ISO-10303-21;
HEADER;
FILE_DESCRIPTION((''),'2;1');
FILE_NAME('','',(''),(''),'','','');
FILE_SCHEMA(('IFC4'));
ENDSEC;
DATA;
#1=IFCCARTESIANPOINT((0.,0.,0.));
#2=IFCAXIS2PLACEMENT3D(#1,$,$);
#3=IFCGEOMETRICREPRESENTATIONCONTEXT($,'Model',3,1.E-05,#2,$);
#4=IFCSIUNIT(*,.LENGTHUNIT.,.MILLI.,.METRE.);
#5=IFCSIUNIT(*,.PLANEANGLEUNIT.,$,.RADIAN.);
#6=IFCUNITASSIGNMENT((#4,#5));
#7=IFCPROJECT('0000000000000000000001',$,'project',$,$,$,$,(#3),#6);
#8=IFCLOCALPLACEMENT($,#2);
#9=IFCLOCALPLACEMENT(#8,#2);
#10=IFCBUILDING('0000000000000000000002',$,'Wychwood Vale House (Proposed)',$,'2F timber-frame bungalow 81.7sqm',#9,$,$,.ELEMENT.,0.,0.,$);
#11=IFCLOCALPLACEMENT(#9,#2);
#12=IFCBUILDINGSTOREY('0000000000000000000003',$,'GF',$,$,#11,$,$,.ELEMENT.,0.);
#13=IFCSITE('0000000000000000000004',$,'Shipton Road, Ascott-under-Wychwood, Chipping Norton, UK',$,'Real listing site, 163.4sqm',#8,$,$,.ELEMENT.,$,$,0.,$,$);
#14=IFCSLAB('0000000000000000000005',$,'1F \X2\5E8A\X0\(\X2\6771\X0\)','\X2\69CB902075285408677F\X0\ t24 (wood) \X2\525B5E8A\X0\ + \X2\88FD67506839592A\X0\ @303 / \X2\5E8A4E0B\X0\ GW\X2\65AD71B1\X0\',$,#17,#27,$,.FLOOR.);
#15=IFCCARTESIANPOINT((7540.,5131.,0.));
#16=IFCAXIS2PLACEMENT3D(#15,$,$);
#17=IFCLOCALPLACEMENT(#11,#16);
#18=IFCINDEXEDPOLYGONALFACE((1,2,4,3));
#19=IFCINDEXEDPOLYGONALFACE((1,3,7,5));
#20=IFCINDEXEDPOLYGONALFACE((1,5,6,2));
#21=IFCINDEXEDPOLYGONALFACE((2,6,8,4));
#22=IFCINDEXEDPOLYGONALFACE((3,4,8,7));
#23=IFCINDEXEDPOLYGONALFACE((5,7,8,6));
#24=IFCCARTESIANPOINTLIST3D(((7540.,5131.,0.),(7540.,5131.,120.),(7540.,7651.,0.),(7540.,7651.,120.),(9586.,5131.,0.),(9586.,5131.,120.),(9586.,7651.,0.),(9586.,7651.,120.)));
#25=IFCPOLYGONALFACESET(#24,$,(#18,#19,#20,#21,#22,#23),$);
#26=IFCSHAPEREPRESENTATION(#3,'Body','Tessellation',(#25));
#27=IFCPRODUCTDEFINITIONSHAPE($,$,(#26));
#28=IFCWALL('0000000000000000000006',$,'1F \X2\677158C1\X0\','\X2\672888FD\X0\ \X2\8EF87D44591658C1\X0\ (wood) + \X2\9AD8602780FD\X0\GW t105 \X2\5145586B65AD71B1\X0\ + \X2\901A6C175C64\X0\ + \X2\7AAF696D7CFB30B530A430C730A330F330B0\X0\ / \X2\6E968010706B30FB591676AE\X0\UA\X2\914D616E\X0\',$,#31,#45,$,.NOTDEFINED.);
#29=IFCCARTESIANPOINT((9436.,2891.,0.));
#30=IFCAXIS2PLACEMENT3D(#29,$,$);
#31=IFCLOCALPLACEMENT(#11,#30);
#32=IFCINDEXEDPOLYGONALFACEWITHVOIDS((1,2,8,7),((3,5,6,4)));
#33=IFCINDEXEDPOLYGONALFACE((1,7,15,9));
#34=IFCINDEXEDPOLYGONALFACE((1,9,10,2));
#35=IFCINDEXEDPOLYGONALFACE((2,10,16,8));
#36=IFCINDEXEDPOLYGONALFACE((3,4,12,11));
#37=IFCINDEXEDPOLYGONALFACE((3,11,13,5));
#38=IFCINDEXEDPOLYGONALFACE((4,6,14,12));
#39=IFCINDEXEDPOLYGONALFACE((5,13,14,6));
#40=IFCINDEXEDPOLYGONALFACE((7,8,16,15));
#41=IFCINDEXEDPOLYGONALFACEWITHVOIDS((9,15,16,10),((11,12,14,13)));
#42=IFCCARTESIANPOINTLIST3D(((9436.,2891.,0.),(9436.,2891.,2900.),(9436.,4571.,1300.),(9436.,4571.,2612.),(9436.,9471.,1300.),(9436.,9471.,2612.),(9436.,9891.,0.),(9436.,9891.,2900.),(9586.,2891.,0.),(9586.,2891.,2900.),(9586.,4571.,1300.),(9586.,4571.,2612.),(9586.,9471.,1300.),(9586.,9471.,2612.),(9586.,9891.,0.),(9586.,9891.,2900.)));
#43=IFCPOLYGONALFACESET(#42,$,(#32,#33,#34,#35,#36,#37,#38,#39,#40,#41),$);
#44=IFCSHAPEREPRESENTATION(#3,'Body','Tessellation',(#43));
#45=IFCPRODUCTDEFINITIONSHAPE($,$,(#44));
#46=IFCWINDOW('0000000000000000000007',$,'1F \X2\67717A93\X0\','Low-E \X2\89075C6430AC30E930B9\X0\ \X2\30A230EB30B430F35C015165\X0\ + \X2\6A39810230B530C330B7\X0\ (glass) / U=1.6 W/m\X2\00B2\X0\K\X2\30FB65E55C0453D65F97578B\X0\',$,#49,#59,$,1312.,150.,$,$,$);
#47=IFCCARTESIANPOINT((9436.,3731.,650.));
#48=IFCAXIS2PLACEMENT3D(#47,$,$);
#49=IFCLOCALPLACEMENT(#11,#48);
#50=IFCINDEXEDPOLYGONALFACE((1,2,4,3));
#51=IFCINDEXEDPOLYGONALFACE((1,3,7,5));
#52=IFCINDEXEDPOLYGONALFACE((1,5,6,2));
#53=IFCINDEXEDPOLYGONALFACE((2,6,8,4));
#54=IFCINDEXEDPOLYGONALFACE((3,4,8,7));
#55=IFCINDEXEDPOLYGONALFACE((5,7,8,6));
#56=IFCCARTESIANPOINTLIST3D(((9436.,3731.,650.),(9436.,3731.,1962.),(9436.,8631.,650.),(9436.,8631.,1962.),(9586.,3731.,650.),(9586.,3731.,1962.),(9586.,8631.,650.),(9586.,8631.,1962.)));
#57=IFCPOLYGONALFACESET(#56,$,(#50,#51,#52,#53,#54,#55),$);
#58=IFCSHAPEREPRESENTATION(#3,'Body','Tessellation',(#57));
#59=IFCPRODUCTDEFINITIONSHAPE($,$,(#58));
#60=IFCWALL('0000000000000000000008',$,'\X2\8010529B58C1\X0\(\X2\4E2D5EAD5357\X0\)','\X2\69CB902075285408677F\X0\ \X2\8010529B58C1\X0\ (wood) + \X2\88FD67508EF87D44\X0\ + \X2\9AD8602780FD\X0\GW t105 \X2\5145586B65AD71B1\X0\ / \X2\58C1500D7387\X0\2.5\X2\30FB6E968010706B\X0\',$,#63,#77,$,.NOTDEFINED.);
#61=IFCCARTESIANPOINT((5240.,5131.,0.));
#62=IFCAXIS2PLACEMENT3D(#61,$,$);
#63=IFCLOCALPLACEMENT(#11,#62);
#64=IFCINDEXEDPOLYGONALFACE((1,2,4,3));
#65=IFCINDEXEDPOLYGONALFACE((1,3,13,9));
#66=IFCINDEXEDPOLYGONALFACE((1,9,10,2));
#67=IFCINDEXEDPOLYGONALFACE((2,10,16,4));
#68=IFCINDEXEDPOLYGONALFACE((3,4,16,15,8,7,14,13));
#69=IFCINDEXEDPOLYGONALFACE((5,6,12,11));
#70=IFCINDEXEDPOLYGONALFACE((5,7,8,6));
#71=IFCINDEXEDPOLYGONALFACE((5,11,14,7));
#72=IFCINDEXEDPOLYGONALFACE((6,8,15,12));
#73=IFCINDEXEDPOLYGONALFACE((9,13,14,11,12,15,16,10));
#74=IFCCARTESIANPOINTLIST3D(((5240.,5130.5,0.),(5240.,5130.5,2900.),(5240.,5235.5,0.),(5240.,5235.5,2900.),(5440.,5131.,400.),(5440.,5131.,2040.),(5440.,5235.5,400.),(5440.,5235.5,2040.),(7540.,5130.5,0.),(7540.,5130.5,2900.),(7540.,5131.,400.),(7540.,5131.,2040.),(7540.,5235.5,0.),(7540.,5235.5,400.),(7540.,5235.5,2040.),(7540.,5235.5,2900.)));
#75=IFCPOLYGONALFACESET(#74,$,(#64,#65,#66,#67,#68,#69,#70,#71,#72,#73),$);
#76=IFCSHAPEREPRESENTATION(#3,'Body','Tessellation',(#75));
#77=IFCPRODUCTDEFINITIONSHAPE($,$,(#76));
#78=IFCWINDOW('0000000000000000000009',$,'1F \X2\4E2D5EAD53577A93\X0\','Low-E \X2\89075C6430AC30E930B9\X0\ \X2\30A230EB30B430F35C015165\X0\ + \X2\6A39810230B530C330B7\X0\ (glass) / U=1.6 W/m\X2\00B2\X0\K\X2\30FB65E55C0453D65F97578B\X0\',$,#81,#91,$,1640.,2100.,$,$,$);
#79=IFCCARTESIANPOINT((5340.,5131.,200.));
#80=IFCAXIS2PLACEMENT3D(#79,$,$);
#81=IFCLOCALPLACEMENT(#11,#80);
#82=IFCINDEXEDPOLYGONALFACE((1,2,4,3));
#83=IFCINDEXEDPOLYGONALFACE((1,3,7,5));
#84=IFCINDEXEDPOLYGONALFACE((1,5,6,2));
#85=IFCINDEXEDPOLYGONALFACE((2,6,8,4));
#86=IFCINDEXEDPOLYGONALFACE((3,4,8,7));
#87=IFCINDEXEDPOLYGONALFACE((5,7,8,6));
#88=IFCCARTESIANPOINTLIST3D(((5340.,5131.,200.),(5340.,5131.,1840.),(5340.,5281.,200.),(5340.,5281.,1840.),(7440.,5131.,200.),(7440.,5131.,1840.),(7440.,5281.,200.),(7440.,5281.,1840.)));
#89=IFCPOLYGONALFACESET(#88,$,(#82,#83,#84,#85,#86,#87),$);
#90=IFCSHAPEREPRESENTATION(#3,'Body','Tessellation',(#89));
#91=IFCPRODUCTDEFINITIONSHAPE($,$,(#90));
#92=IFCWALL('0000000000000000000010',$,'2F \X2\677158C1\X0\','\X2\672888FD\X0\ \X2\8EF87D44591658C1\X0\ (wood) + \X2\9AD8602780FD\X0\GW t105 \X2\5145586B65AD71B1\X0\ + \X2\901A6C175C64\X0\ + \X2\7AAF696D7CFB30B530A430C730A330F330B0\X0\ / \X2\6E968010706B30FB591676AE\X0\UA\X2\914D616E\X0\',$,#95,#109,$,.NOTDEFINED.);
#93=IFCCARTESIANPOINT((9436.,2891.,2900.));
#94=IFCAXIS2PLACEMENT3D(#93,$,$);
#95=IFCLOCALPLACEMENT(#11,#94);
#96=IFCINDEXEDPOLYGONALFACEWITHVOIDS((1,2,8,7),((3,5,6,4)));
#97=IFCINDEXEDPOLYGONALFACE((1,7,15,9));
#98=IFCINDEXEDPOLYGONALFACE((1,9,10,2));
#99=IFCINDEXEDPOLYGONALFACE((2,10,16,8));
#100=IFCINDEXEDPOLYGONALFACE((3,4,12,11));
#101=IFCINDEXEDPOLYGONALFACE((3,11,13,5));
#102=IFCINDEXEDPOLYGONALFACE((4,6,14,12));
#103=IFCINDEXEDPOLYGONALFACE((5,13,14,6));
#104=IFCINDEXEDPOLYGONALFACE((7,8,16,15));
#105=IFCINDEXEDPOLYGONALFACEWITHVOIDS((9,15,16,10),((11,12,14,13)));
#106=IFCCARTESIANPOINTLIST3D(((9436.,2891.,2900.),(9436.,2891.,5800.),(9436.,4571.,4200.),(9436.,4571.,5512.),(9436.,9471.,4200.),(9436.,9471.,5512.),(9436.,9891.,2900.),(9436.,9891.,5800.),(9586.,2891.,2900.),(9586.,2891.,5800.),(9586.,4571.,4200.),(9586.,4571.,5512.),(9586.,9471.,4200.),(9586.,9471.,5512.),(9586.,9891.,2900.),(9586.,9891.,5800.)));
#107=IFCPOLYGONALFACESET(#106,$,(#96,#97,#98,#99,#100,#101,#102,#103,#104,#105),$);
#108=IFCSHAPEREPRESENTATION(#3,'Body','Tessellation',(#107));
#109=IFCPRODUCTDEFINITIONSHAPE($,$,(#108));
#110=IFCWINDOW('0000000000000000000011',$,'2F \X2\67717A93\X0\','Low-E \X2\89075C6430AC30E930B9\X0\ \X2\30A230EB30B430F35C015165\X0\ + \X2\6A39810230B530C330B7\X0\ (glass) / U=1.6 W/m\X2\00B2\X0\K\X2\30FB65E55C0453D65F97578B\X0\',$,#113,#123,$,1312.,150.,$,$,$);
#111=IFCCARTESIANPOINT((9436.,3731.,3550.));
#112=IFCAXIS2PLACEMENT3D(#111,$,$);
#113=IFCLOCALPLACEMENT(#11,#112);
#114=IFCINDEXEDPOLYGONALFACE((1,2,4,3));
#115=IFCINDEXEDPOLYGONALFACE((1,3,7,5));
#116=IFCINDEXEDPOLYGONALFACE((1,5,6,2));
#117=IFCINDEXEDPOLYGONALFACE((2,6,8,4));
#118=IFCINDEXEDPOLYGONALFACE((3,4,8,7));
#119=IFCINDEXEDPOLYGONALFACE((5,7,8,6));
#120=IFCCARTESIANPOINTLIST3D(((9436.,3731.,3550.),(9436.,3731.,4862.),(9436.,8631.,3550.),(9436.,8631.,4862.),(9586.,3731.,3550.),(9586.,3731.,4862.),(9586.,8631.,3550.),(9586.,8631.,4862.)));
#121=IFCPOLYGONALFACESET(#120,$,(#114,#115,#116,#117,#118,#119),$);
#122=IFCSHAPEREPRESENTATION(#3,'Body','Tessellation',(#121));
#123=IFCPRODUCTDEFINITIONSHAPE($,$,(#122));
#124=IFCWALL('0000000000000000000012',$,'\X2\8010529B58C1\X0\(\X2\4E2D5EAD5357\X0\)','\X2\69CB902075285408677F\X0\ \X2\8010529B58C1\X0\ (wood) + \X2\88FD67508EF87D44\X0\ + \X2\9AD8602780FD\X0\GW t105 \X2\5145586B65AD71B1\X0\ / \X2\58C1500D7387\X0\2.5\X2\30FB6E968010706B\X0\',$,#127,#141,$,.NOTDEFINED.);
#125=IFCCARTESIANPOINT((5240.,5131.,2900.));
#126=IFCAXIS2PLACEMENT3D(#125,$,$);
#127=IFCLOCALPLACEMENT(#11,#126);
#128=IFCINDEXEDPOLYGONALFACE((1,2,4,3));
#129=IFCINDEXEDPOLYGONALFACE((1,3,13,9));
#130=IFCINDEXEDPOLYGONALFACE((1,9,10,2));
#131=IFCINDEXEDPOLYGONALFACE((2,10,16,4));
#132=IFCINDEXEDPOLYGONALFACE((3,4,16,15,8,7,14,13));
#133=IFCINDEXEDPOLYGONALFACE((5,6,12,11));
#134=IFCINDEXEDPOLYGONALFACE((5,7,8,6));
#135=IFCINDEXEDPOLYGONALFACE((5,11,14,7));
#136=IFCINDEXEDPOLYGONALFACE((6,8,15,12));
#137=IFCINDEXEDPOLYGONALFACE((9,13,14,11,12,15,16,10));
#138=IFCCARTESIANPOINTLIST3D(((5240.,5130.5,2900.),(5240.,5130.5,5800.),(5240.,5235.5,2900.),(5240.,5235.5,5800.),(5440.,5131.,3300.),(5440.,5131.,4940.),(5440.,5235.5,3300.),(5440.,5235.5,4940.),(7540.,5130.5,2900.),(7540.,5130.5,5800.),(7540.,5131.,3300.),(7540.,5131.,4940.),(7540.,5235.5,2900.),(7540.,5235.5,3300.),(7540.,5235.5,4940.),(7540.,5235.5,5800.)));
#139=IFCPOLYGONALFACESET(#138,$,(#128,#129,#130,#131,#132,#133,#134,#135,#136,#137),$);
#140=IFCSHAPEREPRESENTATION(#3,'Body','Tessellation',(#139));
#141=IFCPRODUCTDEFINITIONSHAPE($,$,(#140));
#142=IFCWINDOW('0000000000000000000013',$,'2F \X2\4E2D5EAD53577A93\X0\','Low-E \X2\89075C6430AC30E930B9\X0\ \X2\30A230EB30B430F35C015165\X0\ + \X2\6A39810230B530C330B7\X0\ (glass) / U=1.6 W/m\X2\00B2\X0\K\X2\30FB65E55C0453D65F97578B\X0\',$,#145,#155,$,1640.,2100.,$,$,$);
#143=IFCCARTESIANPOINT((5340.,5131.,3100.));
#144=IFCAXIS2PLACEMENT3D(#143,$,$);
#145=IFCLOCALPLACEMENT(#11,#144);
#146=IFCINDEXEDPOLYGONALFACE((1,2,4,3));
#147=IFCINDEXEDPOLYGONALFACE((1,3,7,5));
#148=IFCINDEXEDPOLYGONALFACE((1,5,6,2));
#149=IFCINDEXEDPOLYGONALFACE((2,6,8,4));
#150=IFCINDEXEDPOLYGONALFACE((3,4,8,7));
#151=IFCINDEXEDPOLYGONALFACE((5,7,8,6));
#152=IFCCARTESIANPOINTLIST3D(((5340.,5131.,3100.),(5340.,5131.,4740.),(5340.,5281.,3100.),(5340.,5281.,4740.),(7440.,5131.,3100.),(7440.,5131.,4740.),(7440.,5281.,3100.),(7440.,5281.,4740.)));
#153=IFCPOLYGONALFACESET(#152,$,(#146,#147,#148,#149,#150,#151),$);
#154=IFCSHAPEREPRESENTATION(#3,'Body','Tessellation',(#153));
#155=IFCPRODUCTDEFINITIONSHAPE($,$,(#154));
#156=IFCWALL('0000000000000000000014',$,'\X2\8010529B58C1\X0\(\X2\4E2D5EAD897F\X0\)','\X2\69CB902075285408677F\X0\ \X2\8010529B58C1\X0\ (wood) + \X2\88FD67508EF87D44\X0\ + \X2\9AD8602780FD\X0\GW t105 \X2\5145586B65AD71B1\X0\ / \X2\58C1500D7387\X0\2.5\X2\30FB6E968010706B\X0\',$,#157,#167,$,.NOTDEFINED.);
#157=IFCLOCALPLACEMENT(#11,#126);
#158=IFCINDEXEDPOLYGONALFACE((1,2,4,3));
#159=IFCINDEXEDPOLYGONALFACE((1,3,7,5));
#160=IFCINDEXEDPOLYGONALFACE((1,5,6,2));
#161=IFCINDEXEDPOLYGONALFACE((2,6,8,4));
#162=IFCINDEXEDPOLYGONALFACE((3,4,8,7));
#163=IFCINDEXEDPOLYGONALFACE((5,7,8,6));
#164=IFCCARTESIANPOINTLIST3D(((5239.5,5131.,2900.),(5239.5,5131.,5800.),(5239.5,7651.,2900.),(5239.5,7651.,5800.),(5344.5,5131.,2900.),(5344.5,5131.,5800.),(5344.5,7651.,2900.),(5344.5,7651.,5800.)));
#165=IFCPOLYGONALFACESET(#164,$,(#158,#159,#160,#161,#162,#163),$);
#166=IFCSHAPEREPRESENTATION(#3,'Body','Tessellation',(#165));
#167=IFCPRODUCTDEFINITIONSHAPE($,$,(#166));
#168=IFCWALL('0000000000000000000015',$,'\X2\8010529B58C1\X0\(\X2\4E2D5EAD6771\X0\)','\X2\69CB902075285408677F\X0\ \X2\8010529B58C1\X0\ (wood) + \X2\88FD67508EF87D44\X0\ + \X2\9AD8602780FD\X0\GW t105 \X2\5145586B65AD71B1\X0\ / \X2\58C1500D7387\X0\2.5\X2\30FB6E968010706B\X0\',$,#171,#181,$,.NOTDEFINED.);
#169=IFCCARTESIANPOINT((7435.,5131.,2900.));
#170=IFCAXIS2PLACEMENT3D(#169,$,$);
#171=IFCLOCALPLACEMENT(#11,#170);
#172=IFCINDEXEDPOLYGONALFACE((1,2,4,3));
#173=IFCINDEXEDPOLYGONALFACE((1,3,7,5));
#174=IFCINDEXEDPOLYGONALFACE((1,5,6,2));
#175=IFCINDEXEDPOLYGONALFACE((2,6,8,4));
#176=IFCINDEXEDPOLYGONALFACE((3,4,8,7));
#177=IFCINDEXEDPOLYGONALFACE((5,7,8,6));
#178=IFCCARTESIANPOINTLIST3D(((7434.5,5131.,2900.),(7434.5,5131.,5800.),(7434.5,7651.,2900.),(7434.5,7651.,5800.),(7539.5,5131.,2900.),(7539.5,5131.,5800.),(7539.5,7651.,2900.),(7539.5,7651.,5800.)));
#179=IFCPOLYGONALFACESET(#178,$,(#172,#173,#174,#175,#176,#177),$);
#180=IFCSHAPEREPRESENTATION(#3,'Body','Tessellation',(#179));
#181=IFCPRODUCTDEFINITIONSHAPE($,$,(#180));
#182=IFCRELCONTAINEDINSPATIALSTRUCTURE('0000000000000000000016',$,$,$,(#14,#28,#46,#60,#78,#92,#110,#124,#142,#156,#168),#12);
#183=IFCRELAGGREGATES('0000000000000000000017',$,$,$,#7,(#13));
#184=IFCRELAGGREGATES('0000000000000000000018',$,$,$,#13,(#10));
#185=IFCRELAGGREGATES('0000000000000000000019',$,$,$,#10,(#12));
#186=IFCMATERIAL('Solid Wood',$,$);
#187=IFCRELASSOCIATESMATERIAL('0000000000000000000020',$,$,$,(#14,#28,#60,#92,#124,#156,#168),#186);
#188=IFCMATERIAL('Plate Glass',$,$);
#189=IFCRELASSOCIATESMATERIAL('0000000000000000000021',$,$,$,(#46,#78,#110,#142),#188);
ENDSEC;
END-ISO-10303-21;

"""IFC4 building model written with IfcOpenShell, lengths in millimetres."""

from ifc_helpers import new_model, si_unit, frame, frame_2d, origin, place, context, project, spatial, rectangle, extrude, material, element, fill, save


model = new_model("IFC4")

# Units and contexts
model_context = context("Model", 3, precision=1e-05, world=origin())
ifc_project = project(units=[si_unit("LENGTHUNIT", "METRE", prefix="MILLI"), si_unit("PLANEANGLEUNIT", "RADIAN")], contexts=[model_context])

# Site, building, storey
site_placement = place(None, origin())
site = spatial("IfcSite", under=ifc_project, at=site_placement, Name="Shipton Road, Ascott-under-Wychwood, Chipping Norton, UK", ObjectType="Real listing site, 163.4sqm", CompositionType="ELEMENT", RefElevation=0.0)
building_placement = place(site_placement, origin())
building = spatial("IfcBuilding", under=site, at=building_placement, Name="Wychwood Vale House (Proposed)", ObjectType="2F timber-frame bungalow 81.7sqm", CompositionType="ELEMENT", ElevationOfRefHeight=0.0, ElevationOfTerrain=0.0)
storey_placement = place(building_placement, origin())
storey = spatial("IfcBuildingStorey", under=building, at=storey_placement, Name="GF", CompositionType="ELEMENT", Elevation=0.0)

# Slab
ifc_material_1 = material(Name="Solid Wood")
slab_placement = place(storey_placement, frame((7540.0, 5131.0, 0.0)))
element("IfcSlab", 1, at=slab_placement, inside=storey, material=ifc_material_1, Name="1F 床(東)", Description="構造用合板 t24 (wood) 剛床 + 製材根太 @303 / 床下 GW断熱", PredefinedType="FLOOR", context=model_context, shape_type="SweptSolid", body=[
    extrude(rectangle(XDim=2046.0, YDim=2520.0, at=frame_2d((1023.0, 1260.0))), frame((7540.0, 5131.0, 0.0)), (0.0, 0.0, 1.0), 120.0),
])

# Walls, openings, windows
wall_1_placement = place(storey_placement, frame((9436.0, 2891.0, 0.0)))
wall_1 = element("IfcWall", 2, at=wall_1_placement, inside=storey, material=ifc_material_1, Name="1F 東壁", Description="木製 軸組外壁 (wood) + 高性能GW t105 充填断熱 + 通気層 + 窯業系サイディング / 準耐火・外皮UA配慮", PredefinedType="NOTDEFINED", context=model_context, shape_type="SweptSolid", body=[
    extrude(rectangle(XDim=150.0, YDim=7000.0, at=frame_2d((75.0, 3500.0))), frame((9436.0, 2891.0, 0.0)), (0.0, 0.0, 1.0), 2900.0),
])
opening_1_placement = place(storey_placement, frame((9436.0, 3731.0, 650.0)))
opening_1 = element("IfcOpeningElement", 3, at=opening_1_placement, cuts=wall_1, PredefinedType="NOTDEFINED", context=model_context, shape_type="SweptSolid", body=[
    extrude(rectangle(XDim=150.0, YDim=4900.0, at=frame_2d((75.0, 2450.0))), frame((9436.0, 3731.0, 650.0)), (0.0, 0.0, 1.0), 1312.0),
])
ifc_material_2 = material(Name="Plate Glass")
window_1_placement = place(storey_placement, frame((9436.0, 3731.0, 650.0)))
window_1 = element("IfcWindow", 4, at=window_1_placement, inside=storey, material=ifc_material_2, Name="1F 東窓", Description="Low-E 複層ガラス アルゴン封入 + 樹脂サッシ (glass) / U=1.6 W/m²K・日射取得型", OverallHeight=1312.0, OverallWidth=150.0, context=model_context, shape_type="SweptSolid", body=[
    extrude(rectangle(XDim=150.0, YDim=4900.0, at=frame_2d((75.0, 2450.0))), frame((9436.0, 3731.0, 650.0)), (0.0, 0.0, 1.0), 1312.0),
])
fill(opening_1, window_1)
wall_2_placement = place(storey_placement, frame((5240.0, 5131.0, 0.0)))
wall_2 = element("IfcWall", 5, at=wall_2_placement, inside=storey, material=ifc_material_1, Name="耐力壁(中庭南)", Description="構造用合板 耐力壁 (wood) + 製材軸組 + 高性能GW t105 充填断熱 / 壁倍率2.5・準耐火", PredefinedType="NOTDEFINED", context=model_context, shape_type="SweptSolid", body=[
    extrude(rectangle(XDim=2300.0, YDim=105.0, at=frame_2d((1150.0, 52.0))), frame((5240.0, 5131.0, 0.0)), (0.0, 0.0, 1.0), 2900.0),
])
opening_2_placement = place(storey_placement, frame((5340.0, 5131.0, 200.0)))
opening_2 = element("IfcOpeningElement", 6, at=opening_2_placement, cuts=wall_2, PredefinedType="NOTDEFINED", context=model_context, shape_type="SweptSolid", body=[
    extrude(rectangle(XDim=2100.0, YDim=150.0, at=frame_2d((1050.0, 75.0))), frame((5340.0, 5131.0, 200.0)), (0.0, 0.0, 1.0), 1640.0),
])
window_2_placement = place(storey_placement, frame((5340.0, 5131.0, 200.0)))
window_2 = element("IfcWindow", 7, at=window_2_placement, inside=storey, material=ifc_material_2, Name="1F 中庭南窓", Description="Low-E 複層ガラス アルゴン封入 + 樹脂サッシ (glass) / U=1.6 W/m²K・日射取得型", OverallHeight=1640.0, OverallWidth=2100.0, context=model_context, shape_type="SweptSolid", body=[
    extrude(rectangle(XDim=2100.0, YDim=150.0, at=frame_2d((1050.0, 75.0))), frame((5340.0, 5131.0, 200.0)), (0.0, 0.0, 1.0), 1640.0),
])
fill(opening_2, window_2)

# Walls, openings, windows
wall_3_placement = place(storey_placement, frame((9436.0, 2891.0, 2900.0)))
wall_3 = element("IfcWall", 8, at=wall_3_placement, inside=storey, material=ifc_material_1, Name="2F 東壁", Description="木製 軸組外壁 (wood) + 高性能GW t105 充填断熱 + 通気層 + 窯業系サイディング / 準耐火・外皮UA配慮", PredefinedType="NOTDEFINED", context=model_context, shape_type="SweptSolid", body=[
    extrude(rectangle(XDim=150.0, YDim=7000.0, at=frame_2d((75.0, 3500.0))), frame((9436.0, 2891.0, 2900.0)), (0.0, 0.0, 1.0), 2900.0),
])
opening_3_placement = place(storey_placement, frame((9436.0, 3731.0, 3550.0)))
opening_3 = element("IfcOpeningElement", 9, at=opening_3_placement, cuts=wall_3, PredefinedType="NOTDEFINED", context=model_context, shape_type="SweptSolid", body=[
    extrude(rectangle(XDim=150.0, YDim=4900.0, at=frame_2d((75.0, 2450.0))), frame((9436.0, 3731.0, 3550.0)), (0.0, 0.0, 1.0), 1312.0),
])
window_3_placement = place(storey_placement, frame((9436.0, 3731.0, 3550.0)))
window_3 = element("IfcWindow", 10, at=window_3_placement, inside=storey, material=ifc_material_2, Name="2F 東窓", Description="Low-E 複層ガラス アルゴン封入 + 樹脂サッシ (glass) / U=1.6 W/m²K・日射取得型", OverallHeight=1312.0, OverallWidth=150.0, context=model_context, shape_type="SweptSolid", body=[
    extrude(rectangle(XDim=150.0, YDim=4900.0, at=frame_2d((75.0, 2450.0))), frame((9436.0, 3731.0, 3550.0)), (0.0, 0.0, 1.0), 1312.0),
])
fill(opening_3, window_3)
wall_4_placement = place(storey_placement, frame((5240.0, 5131.0, 2900.0)))
wall_4 = element("IfcWall", 11, at=wall_4_placement, inside=storey, material=ifc_material_1, Name="耐力壁(中庭南)", Description="構造用合板 耐力壁 (wood) + 製材軸組 + 高性能GW t105 充填断熱 / 壁倍率2.5・準耐火", PredefinedType="NOTDEFINED", context=model_context, shape_type="SweptSolid", body=[
    extrude(rectangle(XDim=2300.0, YDim=105.0, at=frame_2d((1150.0, 52.0))), frame((5240.0, 5131.0, 2900.0)), (0.0, 0.0, 1.0), 2900.0),
])
opening_4_placement = place(storey_placement, frame((5340.0, 5131.0, 3100.0)))
opening_4 = element("IfcOpeningElement", 12, at=opening_4_placement, cuts=wall_4, PredefinedType="NOTDEFINED", context=model_context, shape_type="SweptSolid", body=[
    extrude(rectangle(XDim=2100.0, YDim=150.0, at=frame_2d((1050.0, 75.0))), frame((5340.0, 5131.0, 3100.0)), (0.0, 0.0, 1.0), 1640.0),
])
window_4_placement = place(storey_placement, frame((5340.0, 5131.0, 3100.0)))
window_4 = element("IfcWindow", 13, at=window_4_placement, inside=storey, material=ifc_material_2, Name="2F 中庭南窓", Description="Low-E 複層ガラス アルゴン封入 + 樹脂サッシ (glass) / U=1.6 W/m²K・日射取得型", OverallHeight=1640.0, OverallWidth=2100.0, context=model_context, shape_type="SweptSolid", body=[
    extrude(rectangle(XDim=2100.0, YDim=150.0, at=frame_2d((1050.0, 75.0))), frame((5340.0, 5131.0, 3100.0)), (0.0, 0.0, 1.0), 1640.0),
])
fill(opening_4, window_4)

# Walls
wall_5_placement = place(storey_placement, frame((5240.0, 5131.0, 2900.0)))
element("IfcWall", 14, at=wall_5_placement, inside=storey, material=ifc_material_1, Name="耐力壁(中庭西)", Description="構造用合板 耐力壁 (wood) + 製材軸組 + 高性能GW t105 充填断熱 / 壁倍率2.5・準耐火", PredefinedType="NOTDEFINED", context=model_context, shape_type="SweptSolid", body=[
    extrude(rectangle(XDim=105.0, YDim=2520.0, at=frame_2d((52.0, 1260.0))), frame((5240.0, 5131.0, 2900.0)), (0.0, 0.0, 1.0), 2900.0),
])
wall_6_placement = place(storey_placement, frame((7435.0, 5131.0, 2900.0)))
element("IfcWall", 15, at=wall_6_placement, inside=storey, material=ifc_material_1, Name="耐力壁(中庭東)", Description="構造用合板 耐力壁 (wood) + 製材軸組 + 高性能GW t105 充填断熱 / 壁倍率2.5・準耐火", PredefinedType="NOTDEFINED", context=model_context, shape_type="SweptSolid", body=[
    extrude(rectangle(XDim=105.0, YDim=2520.0, at=frame_2d((52.0, 1260.0))), frame((7435.0, 5131.0, 2900.0)), (0.0, 0.0, 1.0), 2900.0),
])

save(model, "model.ifc")
